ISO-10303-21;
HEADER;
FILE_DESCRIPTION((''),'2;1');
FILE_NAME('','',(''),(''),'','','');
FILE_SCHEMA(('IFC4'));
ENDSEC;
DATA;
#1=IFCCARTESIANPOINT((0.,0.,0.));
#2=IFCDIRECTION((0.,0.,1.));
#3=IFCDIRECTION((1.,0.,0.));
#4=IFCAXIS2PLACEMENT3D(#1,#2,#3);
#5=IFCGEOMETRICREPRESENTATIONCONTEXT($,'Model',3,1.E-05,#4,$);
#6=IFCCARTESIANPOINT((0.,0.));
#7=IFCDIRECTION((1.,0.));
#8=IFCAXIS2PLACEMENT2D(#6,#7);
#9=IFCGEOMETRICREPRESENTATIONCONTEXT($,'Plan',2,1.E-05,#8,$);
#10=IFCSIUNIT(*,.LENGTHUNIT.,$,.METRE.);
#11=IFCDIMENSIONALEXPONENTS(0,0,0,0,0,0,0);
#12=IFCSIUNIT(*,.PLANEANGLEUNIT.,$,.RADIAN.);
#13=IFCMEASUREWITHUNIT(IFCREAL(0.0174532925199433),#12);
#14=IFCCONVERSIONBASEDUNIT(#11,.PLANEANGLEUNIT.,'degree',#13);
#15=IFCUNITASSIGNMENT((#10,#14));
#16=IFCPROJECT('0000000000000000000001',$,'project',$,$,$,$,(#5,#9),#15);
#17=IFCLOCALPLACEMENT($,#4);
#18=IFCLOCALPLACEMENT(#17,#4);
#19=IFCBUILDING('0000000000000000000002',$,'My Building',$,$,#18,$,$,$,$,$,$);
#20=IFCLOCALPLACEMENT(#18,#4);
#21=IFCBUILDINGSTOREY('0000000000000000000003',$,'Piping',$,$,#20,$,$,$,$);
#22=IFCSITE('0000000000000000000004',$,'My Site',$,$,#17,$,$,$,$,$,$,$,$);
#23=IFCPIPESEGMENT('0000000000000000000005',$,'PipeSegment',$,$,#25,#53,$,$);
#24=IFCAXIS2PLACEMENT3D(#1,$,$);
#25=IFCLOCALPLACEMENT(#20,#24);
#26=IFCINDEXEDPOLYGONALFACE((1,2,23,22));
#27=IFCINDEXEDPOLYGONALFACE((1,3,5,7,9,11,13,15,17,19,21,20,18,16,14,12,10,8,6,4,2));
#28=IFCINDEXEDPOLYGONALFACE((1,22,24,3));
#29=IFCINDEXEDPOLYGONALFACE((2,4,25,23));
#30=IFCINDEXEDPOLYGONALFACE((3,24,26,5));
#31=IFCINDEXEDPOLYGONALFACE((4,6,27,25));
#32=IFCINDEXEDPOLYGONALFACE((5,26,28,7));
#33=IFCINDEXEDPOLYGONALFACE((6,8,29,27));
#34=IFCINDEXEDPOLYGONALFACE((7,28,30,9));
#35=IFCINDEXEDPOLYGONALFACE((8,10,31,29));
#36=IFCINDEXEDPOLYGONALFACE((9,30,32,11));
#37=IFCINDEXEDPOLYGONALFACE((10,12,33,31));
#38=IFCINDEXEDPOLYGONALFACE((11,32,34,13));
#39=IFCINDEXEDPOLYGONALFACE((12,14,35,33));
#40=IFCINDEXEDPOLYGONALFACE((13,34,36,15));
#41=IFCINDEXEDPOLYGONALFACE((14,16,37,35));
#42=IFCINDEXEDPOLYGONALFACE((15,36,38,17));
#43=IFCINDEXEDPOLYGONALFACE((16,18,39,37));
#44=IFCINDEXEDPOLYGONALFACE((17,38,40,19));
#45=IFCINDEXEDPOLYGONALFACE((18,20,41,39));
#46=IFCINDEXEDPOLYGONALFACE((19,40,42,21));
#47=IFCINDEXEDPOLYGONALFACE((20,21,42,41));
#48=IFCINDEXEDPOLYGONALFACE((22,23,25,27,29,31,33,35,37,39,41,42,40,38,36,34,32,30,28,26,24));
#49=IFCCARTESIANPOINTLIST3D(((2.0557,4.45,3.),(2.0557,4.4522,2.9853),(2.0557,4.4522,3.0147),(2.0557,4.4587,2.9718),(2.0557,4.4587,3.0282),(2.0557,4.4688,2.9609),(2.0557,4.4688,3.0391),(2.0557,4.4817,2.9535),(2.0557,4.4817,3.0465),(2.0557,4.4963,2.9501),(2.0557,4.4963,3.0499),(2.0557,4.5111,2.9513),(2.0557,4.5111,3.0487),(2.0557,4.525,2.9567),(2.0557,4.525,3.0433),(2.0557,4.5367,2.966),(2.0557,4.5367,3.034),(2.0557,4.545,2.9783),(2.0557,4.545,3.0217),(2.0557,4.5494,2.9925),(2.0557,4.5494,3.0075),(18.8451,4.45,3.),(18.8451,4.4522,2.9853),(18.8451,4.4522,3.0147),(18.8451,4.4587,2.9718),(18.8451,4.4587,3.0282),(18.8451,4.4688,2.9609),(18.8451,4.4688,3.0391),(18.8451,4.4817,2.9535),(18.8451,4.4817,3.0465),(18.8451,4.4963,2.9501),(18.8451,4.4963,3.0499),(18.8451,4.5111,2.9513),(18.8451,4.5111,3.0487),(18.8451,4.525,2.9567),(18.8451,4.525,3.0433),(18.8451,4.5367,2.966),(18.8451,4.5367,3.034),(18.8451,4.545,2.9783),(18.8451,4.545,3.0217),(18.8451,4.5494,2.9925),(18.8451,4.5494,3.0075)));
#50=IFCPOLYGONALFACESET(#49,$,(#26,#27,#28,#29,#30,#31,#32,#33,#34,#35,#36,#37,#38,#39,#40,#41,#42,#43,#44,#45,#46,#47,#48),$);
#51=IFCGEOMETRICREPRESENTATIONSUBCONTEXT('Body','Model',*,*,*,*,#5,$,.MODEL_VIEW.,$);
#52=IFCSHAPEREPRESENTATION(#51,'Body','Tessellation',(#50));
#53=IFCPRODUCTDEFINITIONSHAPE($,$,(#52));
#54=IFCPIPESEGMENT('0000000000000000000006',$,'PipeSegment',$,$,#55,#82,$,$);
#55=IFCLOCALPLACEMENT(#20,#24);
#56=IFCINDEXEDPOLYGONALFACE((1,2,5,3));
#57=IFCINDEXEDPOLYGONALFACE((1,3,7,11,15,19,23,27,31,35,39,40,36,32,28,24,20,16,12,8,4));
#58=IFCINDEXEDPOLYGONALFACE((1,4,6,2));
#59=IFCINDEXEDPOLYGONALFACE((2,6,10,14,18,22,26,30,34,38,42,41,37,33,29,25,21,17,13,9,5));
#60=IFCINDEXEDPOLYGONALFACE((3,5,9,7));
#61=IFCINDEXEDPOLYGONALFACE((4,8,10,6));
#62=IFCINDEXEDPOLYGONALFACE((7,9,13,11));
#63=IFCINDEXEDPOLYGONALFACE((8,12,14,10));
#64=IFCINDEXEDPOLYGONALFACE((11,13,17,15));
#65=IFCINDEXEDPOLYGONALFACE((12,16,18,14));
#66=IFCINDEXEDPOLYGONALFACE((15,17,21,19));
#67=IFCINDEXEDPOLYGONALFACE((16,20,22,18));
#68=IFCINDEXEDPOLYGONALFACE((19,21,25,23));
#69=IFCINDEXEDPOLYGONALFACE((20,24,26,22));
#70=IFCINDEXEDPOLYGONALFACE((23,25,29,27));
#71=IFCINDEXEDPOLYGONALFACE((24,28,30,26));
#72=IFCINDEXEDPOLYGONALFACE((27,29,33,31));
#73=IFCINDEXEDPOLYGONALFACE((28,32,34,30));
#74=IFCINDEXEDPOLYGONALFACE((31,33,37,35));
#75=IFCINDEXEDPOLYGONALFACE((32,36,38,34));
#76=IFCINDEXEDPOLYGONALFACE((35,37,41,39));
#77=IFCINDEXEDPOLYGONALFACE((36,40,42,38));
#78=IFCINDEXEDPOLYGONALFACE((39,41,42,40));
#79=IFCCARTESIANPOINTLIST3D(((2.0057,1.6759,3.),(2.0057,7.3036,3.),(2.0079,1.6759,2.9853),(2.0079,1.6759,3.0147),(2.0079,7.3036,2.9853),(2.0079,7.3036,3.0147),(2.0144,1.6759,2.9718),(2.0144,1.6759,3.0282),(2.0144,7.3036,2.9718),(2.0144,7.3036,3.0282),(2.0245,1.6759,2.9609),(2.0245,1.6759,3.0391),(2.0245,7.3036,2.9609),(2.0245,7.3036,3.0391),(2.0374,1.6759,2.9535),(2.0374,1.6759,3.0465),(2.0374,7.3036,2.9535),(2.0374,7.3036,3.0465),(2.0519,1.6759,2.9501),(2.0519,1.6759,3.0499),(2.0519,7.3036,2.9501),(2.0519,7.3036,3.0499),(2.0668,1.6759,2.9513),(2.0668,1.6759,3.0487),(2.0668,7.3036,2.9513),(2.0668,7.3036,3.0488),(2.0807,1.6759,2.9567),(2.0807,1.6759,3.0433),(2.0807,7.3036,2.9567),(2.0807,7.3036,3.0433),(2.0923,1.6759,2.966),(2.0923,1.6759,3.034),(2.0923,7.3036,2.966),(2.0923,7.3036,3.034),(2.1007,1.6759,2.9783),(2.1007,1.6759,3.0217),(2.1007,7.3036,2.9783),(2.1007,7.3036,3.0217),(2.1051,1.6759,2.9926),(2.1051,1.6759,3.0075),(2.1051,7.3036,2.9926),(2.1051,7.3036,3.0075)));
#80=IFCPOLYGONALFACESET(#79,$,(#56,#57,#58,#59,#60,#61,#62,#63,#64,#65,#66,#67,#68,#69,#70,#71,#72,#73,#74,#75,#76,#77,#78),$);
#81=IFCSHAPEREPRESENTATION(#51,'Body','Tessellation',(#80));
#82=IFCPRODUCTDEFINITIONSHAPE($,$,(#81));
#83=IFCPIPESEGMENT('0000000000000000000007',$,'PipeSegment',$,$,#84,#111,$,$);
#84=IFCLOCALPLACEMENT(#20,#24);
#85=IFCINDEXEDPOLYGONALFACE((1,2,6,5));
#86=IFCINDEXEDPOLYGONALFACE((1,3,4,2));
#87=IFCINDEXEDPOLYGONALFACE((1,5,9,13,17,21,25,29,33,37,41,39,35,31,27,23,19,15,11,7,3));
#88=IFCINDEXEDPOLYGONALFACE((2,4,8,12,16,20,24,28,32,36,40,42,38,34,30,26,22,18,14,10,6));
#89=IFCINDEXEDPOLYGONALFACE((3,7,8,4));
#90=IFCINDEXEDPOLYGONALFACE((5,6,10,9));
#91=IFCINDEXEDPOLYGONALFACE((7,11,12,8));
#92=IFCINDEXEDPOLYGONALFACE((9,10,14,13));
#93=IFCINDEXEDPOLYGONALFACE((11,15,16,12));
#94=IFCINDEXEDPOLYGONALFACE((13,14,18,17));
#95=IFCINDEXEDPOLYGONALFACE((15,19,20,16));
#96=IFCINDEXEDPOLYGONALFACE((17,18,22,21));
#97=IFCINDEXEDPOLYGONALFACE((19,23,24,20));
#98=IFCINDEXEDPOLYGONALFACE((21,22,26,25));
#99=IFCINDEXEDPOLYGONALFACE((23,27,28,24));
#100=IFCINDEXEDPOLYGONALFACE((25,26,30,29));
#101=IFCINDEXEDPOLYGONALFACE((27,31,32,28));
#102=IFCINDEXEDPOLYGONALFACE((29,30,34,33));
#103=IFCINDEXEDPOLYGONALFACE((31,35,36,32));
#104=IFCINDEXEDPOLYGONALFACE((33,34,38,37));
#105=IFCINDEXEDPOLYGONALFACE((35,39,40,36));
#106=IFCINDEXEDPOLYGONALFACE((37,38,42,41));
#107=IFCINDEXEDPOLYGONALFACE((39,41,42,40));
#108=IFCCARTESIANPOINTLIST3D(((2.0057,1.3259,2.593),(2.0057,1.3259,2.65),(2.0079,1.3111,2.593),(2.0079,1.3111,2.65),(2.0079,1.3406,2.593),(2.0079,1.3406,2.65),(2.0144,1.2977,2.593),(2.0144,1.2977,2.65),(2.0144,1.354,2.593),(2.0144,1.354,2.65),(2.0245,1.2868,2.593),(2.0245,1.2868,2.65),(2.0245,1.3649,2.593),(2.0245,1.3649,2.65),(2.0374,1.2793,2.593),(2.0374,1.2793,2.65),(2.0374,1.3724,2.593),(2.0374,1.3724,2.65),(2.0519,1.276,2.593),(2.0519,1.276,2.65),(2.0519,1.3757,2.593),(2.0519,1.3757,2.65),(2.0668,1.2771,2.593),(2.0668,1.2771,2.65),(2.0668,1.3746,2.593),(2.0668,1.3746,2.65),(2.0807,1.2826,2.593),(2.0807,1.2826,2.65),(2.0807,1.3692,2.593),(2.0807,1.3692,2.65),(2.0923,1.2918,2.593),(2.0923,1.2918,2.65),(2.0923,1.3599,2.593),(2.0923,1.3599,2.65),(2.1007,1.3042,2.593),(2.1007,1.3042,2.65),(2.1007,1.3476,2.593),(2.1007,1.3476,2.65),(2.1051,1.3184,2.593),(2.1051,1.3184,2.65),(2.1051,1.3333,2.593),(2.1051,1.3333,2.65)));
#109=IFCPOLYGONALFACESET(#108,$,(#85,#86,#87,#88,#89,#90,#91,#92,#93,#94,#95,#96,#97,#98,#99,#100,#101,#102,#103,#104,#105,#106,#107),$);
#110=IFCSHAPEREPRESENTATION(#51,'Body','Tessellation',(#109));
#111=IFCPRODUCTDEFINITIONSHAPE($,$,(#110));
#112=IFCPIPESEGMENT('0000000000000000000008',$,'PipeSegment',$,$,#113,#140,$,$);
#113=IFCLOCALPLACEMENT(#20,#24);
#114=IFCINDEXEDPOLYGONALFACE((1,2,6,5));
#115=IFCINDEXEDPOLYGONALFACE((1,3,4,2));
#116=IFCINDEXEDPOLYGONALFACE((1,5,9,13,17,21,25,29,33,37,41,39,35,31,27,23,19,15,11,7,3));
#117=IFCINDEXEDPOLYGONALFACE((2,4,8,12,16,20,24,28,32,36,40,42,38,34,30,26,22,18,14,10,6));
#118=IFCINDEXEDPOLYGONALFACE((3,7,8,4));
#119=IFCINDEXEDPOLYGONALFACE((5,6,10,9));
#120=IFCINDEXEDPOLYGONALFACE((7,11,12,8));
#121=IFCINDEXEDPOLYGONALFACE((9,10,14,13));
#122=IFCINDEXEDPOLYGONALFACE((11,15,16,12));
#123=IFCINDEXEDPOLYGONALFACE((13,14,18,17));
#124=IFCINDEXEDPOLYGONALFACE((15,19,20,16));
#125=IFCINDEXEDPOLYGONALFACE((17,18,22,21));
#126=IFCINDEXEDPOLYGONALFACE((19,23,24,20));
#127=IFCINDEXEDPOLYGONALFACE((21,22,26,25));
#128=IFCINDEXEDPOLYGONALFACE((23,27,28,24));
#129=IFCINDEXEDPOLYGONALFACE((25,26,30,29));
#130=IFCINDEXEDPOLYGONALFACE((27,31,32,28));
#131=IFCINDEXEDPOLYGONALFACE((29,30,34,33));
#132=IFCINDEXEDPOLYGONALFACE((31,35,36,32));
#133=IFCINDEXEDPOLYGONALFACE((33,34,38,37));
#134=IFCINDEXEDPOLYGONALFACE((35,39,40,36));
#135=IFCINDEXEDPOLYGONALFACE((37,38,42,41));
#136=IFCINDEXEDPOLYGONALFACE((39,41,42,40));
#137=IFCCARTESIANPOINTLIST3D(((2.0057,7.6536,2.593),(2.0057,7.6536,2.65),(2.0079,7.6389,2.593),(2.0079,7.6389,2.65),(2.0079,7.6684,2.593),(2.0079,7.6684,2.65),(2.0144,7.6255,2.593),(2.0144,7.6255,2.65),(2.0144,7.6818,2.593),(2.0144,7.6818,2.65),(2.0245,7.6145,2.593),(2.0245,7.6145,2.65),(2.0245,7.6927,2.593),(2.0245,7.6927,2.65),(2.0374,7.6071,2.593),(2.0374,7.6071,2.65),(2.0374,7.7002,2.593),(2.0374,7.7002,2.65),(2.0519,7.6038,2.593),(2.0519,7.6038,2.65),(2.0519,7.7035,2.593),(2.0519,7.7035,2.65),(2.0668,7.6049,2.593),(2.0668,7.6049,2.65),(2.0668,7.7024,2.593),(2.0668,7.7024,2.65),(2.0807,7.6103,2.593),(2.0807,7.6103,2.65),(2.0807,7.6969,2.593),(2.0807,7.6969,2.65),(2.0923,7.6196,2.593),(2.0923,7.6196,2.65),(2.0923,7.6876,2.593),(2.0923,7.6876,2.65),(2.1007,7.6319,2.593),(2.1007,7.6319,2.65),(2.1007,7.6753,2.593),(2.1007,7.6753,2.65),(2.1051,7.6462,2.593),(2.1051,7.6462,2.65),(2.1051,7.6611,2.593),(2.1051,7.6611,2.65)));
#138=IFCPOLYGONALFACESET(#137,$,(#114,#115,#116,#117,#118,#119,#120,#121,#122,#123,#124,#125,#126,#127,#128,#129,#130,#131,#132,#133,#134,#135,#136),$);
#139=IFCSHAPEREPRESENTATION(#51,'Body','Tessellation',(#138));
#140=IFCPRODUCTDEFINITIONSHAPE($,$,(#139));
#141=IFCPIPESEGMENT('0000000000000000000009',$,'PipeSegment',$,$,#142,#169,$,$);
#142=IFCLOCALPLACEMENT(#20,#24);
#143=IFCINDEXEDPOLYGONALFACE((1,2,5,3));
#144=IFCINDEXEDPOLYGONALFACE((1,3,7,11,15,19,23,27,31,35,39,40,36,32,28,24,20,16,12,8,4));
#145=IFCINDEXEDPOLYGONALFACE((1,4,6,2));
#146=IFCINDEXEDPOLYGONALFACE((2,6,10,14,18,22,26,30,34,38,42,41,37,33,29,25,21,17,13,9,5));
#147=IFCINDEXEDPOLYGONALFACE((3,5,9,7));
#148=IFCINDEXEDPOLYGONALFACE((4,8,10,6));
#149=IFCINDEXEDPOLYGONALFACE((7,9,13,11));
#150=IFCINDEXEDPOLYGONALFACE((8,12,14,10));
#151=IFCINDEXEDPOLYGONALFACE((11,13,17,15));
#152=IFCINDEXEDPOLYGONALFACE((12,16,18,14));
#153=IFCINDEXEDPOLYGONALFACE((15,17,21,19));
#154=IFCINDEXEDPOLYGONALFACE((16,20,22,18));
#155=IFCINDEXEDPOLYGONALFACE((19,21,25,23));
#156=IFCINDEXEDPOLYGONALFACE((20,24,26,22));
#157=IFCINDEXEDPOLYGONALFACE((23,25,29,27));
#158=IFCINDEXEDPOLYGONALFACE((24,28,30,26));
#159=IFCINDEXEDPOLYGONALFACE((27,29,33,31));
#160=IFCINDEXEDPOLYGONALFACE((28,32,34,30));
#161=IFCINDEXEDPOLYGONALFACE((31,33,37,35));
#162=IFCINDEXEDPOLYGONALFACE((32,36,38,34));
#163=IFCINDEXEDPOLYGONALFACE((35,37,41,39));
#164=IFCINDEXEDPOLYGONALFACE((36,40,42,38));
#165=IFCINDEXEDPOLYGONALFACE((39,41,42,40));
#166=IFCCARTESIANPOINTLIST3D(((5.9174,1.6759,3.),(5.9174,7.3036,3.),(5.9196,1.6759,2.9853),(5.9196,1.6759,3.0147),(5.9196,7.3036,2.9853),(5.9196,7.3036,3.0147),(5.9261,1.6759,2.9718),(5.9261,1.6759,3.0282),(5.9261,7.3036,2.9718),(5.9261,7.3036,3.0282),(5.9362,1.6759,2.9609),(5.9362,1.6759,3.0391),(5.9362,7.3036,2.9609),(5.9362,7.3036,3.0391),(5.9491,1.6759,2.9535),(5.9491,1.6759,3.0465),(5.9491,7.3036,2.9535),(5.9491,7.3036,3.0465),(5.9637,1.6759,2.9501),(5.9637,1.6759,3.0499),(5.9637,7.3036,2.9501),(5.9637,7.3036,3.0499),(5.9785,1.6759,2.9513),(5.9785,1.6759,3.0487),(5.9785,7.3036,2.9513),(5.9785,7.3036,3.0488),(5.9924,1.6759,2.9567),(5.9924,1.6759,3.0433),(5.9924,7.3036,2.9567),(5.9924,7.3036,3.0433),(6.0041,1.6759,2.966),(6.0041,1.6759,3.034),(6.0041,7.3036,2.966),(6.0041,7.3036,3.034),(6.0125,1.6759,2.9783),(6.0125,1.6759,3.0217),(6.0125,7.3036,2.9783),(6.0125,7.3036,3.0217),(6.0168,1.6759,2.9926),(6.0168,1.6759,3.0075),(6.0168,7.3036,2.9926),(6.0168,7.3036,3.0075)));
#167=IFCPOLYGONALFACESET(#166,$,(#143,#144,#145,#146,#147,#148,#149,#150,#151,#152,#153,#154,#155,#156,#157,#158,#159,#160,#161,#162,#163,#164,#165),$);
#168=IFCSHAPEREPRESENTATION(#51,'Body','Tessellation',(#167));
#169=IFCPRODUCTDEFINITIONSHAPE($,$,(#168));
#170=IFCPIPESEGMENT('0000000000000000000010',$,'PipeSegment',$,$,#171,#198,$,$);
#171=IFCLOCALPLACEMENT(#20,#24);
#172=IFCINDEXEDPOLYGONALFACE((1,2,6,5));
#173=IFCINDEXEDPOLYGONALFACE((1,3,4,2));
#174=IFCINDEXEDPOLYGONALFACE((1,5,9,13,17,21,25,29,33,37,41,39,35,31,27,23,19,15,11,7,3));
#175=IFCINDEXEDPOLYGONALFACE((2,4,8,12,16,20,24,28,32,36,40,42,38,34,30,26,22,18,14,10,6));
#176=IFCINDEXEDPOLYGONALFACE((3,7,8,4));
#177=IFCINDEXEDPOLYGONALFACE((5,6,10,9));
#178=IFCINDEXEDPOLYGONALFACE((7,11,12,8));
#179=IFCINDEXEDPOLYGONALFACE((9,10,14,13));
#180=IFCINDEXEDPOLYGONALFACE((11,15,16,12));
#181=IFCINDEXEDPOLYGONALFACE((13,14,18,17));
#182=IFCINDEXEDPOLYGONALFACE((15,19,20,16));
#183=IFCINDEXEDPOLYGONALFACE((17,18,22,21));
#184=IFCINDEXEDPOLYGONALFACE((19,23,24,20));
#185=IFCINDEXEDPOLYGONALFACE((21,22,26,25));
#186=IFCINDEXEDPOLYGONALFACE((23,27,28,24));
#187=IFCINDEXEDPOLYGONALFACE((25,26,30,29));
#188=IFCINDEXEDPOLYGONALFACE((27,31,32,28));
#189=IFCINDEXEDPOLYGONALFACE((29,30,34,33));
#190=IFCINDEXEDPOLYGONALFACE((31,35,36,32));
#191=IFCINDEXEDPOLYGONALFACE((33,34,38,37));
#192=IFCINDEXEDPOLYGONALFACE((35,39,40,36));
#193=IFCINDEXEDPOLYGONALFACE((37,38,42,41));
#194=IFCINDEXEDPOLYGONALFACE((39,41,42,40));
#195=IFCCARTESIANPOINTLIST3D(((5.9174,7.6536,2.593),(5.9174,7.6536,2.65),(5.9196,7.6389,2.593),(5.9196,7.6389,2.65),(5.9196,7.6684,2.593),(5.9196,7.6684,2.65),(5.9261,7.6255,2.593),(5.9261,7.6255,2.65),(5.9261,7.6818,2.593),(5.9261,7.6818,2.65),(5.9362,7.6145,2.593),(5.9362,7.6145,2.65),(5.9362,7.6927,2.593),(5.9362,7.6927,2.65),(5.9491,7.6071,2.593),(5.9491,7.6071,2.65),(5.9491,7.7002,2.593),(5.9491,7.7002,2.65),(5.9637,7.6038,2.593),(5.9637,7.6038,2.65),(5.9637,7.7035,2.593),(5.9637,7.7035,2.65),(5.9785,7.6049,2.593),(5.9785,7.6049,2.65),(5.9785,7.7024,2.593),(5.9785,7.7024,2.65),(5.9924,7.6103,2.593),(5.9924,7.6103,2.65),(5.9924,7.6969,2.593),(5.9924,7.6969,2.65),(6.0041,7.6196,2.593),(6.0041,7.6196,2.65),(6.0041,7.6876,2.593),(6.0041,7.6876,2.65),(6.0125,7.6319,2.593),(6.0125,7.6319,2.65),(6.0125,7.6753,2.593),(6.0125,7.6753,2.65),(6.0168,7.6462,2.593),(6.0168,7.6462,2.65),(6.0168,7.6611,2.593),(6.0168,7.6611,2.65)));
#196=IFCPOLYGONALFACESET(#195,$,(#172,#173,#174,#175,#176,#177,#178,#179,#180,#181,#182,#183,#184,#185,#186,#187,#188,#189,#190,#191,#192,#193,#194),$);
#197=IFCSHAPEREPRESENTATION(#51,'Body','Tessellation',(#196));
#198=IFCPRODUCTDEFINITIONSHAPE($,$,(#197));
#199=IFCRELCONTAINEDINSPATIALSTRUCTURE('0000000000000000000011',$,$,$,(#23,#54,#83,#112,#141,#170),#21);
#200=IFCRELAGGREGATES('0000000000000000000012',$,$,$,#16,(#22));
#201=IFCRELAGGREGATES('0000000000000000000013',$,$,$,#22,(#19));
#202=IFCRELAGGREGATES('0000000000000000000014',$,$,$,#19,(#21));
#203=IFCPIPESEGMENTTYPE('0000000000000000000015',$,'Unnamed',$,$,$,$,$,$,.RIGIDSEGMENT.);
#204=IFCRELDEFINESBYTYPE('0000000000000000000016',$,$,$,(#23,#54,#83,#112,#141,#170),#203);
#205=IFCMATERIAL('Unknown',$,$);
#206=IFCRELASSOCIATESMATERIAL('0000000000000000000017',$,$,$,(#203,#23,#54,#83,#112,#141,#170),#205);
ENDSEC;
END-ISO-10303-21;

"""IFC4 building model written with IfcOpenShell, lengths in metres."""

from ifc_helpers import new_model, entity, si_unit, converted_unit, frame, origin_with_axes, origin_2d_with_axis, place, context, subcontext, project, spatial, circle, extrude, material, material_profile, profile_set, profile_usage, type_object, element, save


model = new_model("IFC4")

# Units and contexts
model_context = context("Model", 3, precision=1e-05, world=origin_with_axes())
plan_context = context("Plan", 2, precision=1e-05, world=origin_2d_with_axis())
body_context = subcontext(model_context, "Body", "Model", "MODEL_VIEW")
ifc_project = project(units=[si_unit("LENGTHUNIT", "METRE"), converted_unit("PLANEANGLEUNIT", "degree", entity("IfcReal", 0.0174532925199433), si_unit("PLANEANGLEUNIT", "RADIAN"), dimensions=[0, 0, 0, 0, 0, 0, 0])], contexts=[model_context, plan_context])

# Site, building, storey
site_placement = place(None, origin_with_axes())
site = spatial("IfcSite", under=ifc_project, at=site_placement, Name="My Site")
building_placement = place(site_placement, origin_with_axes())
building = spatial("IfcBuilding", under=site, at=building_placement, Name="My Building")
storey_placement = place(building_placement, origin_with_axes())
storey = spatial("IfcBuildingStorey", under=building, at=storey_placement, Name="Piping")

# Pipe segments
ifc_material = material(Name="Unknown")
ifc_material_profile = material_profile(ifc_material, circle(Radius=0.05))
ifc_profile_set = profile_set([ifc_material_profile])
ifc_profile_usage_1 = profile_usage(ifc_profile_set, cardinal=5)
pipe_segment_type = type_object("IfcPipeSegmentType", Name="Unnamed", PredefinedType="RIGIDSEGMENT", material=ifc_profile_set)
pipe_segment_1_placement = place(storey_placement, frame((18.8451, 4.5, 3.0), z_axis=(-1.0, 0.0, 0.0), x_axis=(0.0, -1.0, 0.0)))
element("IfcPipeSegment", 1, at=pipe_segment_1_placement, inside=storey, type_object=pipe_segment_type, material=ifc_profile_usage_1, Name="PipeSegment", context=body_context, shape_type="SweptSolid", body=[
    extrude(circle(Radius=0.05), origin_with_axes(), (0.0, 0.0, 1.0), 16.7894),
])
ifc_profile_usage_2 = profile_usage(ifc_profile_set, cardinal=5)
pipe_segment_2_placement = place(storey_placement, frame((2.0557, 1.6759, 3.0), z_axis=(0.0, 1.0, 0.0), x_axis=(-1.0, 0.0, 0.0)))
element("IfcPipeSegment", 2, at=pipe_segment_2_placement, inside=storey, type_object=pipe_segment_type, material=ifc_profile_usage_2, Name="PipeSegment", context=body_context, shape_type="SweptSolid", body=[
    extrude(circle(Radius=0.05), origin_with_axes(), (0.0, 0.0, 1.0), 5.6278),
])
ifc_profile_usage_3 = profile_usage(ifc_profile_set, cardinal=5)
pipe_segment_3_placement = place(storey_placement, frame((2.0557, 1.3259, 2.65), z_axis=(0.0, 0.0, -1.0), x_axis=(-1.0, 0.0, 0.0)))
element("IfcPipeSegment", 3, at=pipe_segment_3_placement, inside=storey, type_object=pipe_segment_type, material=ifc_profile_usage_3, Name="PipeSegment", context=body_context, shape_type="SweptSolid", body=[
    extrude(circle(Radius=0.05), origin_with_axes(), (0.0, 0.0, 1.0), 0.057),
])
ifc_profile_usage_4 = profile_usage(ifc_profile_set, cardinal=5)
pipe_segment_4_placement = place(storey_placement, frame((2.0557, 7.6536, 2.65), z_axis=(0.0, 0.0, -1.0), x_axis=(-1.0, 0.0, 0.0)))
element("IfcPipeSegment", 4, at=pipe_segment_4_placement, inside=storey, type_object=pipe_segment_type, material=ifc_profile_usage_4, Name="PipeSegment", context=body_context, shape_type="SweptSolid", body=[
    extrude(circle(Radius=0.05), origin_with_axes(), (0.0, 0.0, 1.0), 0.057),
])
ifc_profile_usage_5 = profile_usage(ifc_profile_set, cardinal=5)
pipe_segment_5_placement = place(storey_placement, frame((5.9674, 1.6759, 3.0), z_axis=(0.0, 1.0, 0.0), x_axis=(-1.0, 0.0, 0.0)))
element("IfcPipeSegment", 5, at=pipe_segment_5_placement, inside=storey, type_object=pipe_segment_type, material=ifc_profile_usage_5, Name="PipeSegment", context=body_context, shape_type="SweptSolid", body=[
    extrude(circle(Radius=0.05), origin_with_axes(), (0.0, 0.0, 1.0), 5.6278),
])
ifc_profile_usage_6 = profile_usage(ifc_profile_set, cardinal=5)
pipe_segment_6_placement = place(storey_placement, frame((5.9674, 7.6536, 2.65), z_axis=(0.0, 0.0, -1.0), x_axis=(-1.0, 0.0, 0.0)))
element("IfcPipeSegment", 6, at=pipe_segment_6_placement, inside=storey, type_object=pipe_segment_type, material=ifc_profile_usage_6, Name="PipeSegment", context=body_context, shape_type="SweptSolid", body=[
    extrude(circle(Radius=0.05), origin_with_axes(), (0.0, 0.0, 1.0), 0.057),
])

save(model, "model.ifc")
